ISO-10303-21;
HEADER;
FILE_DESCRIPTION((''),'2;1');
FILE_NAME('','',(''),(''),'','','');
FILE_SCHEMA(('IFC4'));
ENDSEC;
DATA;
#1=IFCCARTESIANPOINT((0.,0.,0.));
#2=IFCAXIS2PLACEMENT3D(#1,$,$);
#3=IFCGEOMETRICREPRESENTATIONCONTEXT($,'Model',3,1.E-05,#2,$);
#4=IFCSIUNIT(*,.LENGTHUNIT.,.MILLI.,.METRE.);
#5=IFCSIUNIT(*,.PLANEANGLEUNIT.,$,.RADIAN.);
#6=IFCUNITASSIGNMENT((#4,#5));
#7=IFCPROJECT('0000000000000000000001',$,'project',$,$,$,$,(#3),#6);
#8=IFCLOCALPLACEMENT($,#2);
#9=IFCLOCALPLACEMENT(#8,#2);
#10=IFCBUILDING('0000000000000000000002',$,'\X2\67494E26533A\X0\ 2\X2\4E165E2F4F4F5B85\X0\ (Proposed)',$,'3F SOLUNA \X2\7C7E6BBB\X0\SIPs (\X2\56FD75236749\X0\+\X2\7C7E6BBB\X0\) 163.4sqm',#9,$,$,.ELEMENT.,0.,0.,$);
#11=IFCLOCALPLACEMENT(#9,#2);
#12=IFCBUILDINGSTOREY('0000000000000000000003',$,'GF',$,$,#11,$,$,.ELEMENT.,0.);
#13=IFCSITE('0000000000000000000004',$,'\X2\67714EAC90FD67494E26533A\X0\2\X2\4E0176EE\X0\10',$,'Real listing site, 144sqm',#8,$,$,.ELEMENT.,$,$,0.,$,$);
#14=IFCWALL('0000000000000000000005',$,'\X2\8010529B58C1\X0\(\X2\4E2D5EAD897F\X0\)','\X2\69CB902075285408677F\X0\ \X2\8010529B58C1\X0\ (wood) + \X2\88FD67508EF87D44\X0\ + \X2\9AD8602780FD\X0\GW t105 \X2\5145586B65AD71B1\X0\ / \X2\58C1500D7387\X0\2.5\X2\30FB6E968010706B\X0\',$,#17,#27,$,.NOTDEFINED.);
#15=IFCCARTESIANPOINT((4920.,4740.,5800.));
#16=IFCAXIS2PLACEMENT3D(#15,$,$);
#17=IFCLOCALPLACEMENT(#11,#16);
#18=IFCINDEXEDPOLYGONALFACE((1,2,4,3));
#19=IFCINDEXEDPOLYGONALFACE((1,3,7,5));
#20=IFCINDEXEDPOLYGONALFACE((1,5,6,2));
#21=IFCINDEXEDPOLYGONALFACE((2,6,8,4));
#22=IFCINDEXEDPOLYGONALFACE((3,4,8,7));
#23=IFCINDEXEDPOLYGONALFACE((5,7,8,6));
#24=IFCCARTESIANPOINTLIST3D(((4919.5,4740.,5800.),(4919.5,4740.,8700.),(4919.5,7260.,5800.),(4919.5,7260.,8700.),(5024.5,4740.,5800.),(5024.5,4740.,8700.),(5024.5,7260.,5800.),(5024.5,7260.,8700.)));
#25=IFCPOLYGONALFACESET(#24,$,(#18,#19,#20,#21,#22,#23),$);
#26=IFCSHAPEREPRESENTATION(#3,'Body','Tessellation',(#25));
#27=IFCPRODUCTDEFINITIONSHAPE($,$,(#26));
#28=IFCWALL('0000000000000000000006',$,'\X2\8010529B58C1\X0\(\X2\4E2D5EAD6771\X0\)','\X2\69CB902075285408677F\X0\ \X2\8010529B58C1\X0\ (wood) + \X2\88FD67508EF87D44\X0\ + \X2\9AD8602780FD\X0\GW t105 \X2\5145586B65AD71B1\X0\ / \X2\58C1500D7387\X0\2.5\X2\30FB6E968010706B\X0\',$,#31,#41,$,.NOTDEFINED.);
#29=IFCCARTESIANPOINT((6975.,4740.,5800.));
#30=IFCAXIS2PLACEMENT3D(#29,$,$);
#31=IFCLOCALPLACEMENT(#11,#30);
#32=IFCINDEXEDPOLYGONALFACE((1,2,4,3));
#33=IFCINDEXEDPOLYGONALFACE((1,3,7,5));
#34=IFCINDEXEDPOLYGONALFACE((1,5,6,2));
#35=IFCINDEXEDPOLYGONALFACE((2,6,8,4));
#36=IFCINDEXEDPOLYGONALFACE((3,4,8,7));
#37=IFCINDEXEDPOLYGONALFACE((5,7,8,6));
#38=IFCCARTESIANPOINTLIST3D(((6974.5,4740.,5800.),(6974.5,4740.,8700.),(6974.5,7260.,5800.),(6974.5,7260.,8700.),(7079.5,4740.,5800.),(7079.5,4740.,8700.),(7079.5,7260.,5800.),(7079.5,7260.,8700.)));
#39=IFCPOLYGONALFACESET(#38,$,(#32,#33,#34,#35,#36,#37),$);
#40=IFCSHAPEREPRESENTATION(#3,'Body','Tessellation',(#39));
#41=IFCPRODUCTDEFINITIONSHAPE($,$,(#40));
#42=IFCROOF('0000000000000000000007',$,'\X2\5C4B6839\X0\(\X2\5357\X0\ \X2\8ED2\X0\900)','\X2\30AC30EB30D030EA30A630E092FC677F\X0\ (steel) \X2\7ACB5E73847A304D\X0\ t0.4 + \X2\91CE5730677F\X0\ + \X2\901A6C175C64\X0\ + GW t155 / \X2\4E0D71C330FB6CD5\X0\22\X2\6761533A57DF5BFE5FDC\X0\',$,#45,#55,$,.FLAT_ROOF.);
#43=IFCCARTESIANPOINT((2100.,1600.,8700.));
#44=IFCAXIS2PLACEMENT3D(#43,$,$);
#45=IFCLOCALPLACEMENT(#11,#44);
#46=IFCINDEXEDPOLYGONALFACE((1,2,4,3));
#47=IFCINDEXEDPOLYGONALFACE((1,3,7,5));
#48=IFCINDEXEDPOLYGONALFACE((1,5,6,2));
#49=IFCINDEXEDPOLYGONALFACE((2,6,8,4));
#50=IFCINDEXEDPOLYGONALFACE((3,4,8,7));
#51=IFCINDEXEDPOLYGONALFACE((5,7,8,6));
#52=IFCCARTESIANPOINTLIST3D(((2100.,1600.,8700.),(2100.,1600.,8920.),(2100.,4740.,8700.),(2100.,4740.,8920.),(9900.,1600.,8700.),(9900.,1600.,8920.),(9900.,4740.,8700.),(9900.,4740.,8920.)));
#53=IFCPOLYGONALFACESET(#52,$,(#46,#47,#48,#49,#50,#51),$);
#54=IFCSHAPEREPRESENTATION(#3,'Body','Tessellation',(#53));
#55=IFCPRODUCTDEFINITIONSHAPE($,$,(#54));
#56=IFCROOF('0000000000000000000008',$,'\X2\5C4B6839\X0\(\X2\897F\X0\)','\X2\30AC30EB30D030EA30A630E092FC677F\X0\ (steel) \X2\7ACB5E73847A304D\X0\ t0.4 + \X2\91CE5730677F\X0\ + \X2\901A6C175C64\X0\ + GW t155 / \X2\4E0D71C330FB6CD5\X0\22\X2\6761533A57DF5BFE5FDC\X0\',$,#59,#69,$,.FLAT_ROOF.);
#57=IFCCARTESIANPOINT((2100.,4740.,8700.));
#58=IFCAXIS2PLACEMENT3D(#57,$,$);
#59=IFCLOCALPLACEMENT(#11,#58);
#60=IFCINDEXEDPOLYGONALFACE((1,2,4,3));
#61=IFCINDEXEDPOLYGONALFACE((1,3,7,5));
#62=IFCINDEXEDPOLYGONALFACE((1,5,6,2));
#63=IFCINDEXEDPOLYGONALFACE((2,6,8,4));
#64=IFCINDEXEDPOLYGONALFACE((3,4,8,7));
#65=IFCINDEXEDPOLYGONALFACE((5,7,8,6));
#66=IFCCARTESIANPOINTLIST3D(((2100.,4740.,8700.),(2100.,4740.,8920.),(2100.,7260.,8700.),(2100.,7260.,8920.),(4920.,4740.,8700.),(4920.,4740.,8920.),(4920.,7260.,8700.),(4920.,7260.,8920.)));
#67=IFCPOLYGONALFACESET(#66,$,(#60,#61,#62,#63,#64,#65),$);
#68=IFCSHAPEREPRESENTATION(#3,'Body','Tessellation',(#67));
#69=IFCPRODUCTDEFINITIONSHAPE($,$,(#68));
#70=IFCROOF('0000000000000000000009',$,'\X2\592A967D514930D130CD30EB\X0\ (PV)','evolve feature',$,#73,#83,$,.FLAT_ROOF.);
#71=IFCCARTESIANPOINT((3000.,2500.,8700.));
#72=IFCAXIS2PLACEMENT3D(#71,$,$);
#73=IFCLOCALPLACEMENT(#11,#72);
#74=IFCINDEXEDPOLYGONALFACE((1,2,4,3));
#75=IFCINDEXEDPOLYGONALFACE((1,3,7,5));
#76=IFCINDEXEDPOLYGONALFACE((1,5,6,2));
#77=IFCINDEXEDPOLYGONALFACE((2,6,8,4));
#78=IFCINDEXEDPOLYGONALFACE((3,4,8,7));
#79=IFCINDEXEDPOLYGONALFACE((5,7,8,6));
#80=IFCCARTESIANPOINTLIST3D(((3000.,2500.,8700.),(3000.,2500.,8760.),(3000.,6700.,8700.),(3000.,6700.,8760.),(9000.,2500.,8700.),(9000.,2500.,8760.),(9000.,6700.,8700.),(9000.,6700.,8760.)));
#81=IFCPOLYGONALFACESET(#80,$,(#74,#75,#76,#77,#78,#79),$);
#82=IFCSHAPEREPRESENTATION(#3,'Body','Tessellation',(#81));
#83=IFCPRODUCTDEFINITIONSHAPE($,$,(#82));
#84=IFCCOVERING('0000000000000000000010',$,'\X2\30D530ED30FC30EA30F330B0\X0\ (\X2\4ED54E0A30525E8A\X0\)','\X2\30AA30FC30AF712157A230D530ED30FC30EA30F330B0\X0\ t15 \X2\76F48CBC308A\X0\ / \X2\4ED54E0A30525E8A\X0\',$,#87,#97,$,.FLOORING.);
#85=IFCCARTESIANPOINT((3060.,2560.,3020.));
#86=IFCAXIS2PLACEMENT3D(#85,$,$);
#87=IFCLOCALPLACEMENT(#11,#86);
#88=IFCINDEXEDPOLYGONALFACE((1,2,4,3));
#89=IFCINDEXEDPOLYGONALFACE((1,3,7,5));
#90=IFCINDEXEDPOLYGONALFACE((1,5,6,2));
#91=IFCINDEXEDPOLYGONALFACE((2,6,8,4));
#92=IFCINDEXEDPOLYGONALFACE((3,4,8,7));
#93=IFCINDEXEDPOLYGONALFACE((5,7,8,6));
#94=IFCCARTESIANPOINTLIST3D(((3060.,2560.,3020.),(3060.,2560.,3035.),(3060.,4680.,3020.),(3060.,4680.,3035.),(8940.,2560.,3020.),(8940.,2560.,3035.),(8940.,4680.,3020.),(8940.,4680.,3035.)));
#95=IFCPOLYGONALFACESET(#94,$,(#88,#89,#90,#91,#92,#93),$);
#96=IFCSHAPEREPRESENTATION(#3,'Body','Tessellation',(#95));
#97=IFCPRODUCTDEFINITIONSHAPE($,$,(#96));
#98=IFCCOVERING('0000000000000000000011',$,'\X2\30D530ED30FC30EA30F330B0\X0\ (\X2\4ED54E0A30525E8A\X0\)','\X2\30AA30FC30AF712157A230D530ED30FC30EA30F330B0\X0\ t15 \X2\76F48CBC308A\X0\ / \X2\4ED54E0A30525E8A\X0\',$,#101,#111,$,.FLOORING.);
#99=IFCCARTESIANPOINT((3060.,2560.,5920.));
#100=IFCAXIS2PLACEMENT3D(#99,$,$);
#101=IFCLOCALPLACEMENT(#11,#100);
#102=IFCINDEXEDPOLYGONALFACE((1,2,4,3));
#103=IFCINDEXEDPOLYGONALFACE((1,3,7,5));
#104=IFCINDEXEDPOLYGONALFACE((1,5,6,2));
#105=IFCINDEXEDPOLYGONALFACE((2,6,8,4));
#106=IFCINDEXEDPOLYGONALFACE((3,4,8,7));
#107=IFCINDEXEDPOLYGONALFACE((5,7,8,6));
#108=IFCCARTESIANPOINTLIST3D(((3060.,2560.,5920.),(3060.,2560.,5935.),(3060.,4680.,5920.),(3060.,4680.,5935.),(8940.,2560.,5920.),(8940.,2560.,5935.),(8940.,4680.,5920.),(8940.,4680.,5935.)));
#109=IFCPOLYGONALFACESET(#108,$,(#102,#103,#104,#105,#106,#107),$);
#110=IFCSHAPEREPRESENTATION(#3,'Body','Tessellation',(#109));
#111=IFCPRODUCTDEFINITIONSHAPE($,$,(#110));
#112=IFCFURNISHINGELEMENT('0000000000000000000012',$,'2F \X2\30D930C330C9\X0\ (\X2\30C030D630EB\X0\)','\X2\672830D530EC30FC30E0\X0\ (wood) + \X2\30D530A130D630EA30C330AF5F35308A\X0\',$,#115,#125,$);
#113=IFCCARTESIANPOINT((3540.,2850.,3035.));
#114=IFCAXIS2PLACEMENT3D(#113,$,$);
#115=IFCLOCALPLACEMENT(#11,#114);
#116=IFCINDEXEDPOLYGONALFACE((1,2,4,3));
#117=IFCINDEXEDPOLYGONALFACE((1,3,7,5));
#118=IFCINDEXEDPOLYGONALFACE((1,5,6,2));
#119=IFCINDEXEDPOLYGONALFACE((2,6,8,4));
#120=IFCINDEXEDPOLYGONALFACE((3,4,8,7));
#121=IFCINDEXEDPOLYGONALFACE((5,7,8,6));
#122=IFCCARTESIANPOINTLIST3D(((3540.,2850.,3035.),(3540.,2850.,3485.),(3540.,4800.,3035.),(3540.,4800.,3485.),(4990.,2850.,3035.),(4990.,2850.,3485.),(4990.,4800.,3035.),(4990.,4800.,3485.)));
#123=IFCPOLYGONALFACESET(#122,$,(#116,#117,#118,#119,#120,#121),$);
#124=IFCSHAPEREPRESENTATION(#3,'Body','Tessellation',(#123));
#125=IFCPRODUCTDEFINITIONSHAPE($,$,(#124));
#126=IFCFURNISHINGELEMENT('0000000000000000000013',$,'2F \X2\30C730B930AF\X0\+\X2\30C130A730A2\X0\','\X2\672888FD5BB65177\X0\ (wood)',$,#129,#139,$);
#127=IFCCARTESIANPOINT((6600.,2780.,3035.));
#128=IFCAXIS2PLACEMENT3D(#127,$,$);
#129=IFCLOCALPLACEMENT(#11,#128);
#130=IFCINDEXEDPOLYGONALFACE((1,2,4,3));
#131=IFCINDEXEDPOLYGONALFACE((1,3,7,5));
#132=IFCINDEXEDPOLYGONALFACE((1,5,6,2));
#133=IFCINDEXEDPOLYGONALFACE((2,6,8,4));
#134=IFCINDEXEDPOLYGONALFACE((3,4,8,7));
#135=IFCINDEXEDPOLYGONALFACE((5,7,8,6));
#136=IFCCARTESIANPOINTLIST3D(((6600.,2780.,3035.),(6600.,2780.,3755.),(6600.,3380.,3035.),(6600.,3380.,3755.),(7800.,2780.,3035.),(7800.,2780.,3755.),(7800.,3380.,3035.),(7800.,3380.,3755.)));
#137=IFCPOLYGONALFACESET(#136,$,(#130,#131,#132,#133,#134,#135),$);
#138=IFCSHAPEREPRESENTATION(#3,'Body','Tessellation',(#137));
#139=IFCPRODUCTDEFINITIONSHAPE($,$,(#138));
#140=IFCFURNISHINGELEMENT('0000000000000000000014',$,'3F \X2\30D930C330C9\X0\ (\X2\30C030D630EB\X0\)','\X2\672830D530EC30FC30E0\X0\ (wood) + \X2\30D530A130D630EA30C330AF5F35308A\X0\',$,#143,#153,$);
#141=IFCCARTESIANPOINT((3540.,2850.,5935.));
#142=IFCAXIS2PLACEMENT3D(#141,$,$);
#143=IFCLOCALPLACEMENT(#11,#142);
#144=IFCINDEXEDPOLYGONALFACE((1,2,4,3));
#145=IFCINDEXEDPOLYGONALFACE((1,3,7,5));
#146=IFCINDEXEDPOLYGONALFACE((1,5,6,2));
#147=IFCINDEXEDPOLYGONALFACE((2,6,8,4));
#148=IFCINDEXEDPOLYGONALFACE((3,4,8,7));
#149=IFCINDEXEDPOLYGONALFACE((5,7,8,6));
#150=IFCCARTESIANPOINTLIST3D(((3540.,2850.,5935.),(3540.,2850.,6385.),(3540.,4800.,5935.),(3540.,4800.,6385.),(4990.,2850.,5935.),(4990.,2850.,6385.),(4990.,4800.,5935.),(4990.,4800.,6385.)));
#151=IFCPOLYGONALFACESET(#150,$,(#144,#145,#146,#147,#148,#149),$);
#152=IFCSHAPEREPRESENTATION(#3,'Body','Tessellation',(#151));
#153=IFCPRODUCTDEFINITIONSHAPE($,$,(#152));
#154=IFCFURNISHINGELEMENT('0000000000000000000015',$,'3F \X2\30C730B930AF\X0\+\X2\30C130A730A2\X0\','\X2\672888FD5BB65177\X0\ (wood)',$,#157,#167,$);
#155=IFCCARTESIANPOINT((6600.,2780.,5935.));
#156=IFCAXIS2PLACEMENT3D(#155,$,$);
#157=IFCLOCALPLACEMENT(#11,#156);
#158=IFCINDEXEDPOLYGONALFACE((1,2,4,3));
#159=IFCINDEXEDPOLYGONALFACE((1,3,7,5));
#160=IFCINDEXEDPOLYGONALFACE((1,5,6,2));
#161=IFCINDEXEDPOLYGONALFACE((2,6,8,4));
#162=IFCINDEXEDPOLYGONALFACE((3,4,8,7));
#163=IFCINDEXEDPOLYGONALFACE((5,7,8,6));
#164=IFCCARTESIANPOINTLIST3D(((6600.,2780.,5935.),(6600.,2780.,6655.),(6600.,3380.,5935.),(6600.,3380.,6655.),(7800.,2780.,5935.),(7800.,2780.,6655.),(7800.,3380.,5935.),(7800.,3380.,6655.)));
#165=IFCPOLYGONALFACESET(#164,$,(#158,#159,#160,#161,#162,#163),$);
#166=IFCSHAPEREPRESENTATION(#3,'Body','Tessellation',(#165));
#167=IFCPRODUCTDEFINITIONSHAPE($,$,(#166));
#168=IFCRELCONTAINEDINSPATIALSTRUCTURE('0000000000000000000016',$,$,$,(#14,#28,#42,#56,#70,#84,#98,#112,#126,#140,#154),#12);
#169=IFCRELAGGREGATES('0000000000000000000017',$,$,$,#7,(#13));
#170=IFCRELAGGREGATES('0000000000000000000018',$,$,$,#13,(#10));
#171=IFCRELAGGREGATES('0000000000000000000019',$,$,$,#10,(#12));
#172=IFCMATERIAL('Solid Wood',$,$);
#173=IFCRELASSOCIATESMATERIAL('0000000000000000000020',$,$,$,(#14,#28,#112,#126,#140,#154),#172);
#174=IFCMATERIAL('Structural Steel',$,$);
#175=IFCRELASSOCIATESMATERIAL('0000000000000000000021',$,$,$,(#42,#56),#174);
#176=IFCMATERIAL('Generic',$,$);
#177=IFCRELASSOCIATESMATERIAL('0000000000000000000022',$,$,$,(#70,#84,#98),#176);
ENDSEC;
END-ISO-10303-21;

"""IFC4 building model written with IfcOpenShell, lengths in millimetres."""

from ifc_helpers import new_model, si_unit, frame, frame_2d, origin, place, context, project, spatial, rectangle, extrude, material, element, save


model = new_model("IFC4")

# Units and contexts
model_context = context("Model", 3, precision=1e-05, world=origin())
ifc_project = project(units=[si_unit("LENGTHUNIT", "METRE", prefix="MILLI"), si_unit("PLANEANGLEUNIT", "RADIAN")], contexts=[model_context])

# Site, building, storey
site_placement = place(None, origin())
site = spatial("IfcSite", under=ifc_project, at=site_placement, Name="東京都杉並区2丁目10", ObjectType="Real listing site, 144sqm", CompositionType="ELEMENT", RefElevation=0.0)
building_placement = place(site_placement, origin())
building = spatial("IfcBuilding", under=site, at=building_placement, Name="杉並区 2世帯住宅 (Proposed)", ObjectType="3F SOLUNA 籾殻SIPs (国産杉+籾殻) 163.4sqm", CompositionType="ELEMENT", ElevationOfRefHeight=0.0, ElevationOfTerrain=0.0)
storey_placement = place(building_placement, origin())
storey = spatial("IfcBuildingStorey", under=building, at=storey_placement, Name="GF", CompositionType="ELEMENT", Elevation=0.0)

# Shared definitions
ifc_material_1 = material(Name="Solid Wood")

# Walls
wall_1_placement = place(storey_placement, frame((4920.0, 4740.0, 5800.0)))
element("IfcWall", 1, at=wall_1_placement, inside=storey, material=ifc_material_1, Name="耐力壁(中庭西)", Description="構造用合板 耐力壁 (wood) + 製材軸組 + 高性能GW t105 充填断熱 / 壁倍率2.5・準耐火", PredefinedType="NOTDEFINED", context=model_context, shape_type="SweptSolid", body=[
    extrude(rectangle(XDim=105.0, YDim=2520.0, at=frame_2d((52.0, 1260.0))), frame((4920.0, 4740.0, 5800.0)), (0.0, 0.0, 1.0), 2900.0),
])
wall_2_placement = place(storey_placement, frame((6975.0, 4740.0, 5800.0)))
element("IfcWall", 2, at=wall_2_placement, inside=storey, material=ifc_material_1, Name="耐力壁(中庭東)", Description="構造用合板 耐力壁 (wood) + 製材軸組 + 高性能GW t105 充填断熱 / 壁倍率2.5・準耐火", PredefinedType="NOTDEFINED", context=model_context, shape_type="SweptSolid", body=[
    extrude(rectangle(XDim=105.0, YDim=2520.0, at=frame_2d((52.0, 1260.0))), frame((6975.0, 4740.0, 5800.0)), (0.0, 0.0, 1.0), 2900.0),
])

# Roofs
ifc_material_2 = material(Name="Structural Steel")
roof_1_placement = place(storey_placement, frame((2100.0, 1600.0, 8700.0)))
element("IfcRoof", 3, at=roof_1_placement, inside=storey, material=ifc_material_2, Name="屋根(南 軒900)", Description="ガルバリウム鋼板 (steel) 立平葺き t0.4 + 野地板 + 通気層 + GW t155 / 不燃・法22条区域対応", PredefinedType="FLAT_ROOF", context=model_context, shape_type="SweptSolid", body=[
    extrude(rectangle(XDim=7800.0, YDim=3140.0, at=frame_2d((3900.0, 1570.0))), frame((2100.0, 1600.0, 8700.0)), (0.0, 0.0, 1.0), 220.0),
])
roof_2_placement = place(storey_placement, frame((2100.0, 4740.0, 8700.0)))
element("IfcRoof", 4, at=roof_2_placement, inside=storey, material=ifc_material_2, Name="屋根(西)", Description="ガルバリウム鋼板 (steel) 立平葺き t0.4 + 野地板 + 通気層 + GW t155 / 不燃・法22条区域対応", PredefinedType="FLAT_ROOF", context=model_context, shape_type="SweptSolid", body=[
    extrude(rectangle(XDim=2820.0, YDim=2520.0, at=frame_2d((1410.0, 1260.0))), frame((2100.0, 4740.0, 8700.0)), (0.0, 0.0, 1.0), 220.0),
])
ifc_material_3 = material(Name="Generic")
roof_3_placement = place(storey_placement, frame((3000.0, 2500.0, 8700.0)))
element("IfcRoof", 5, at=roof_3_placement, inside=storey, material=ifc_material_3, Name="太陽光パネル (PV)", Description="evolve feature", PredefinedType="FLAT_ROOF", context=model_context, shape_type="SweptSolid", body=[
    extrude(rectangle(XDim=6000.0, YDim=4200.0, at=frame_2d((3000.0, 2100.0))), frame((3000.0, 2500.0, 8700.0)), (0.0, 0.0, 1.0), 60.0),
])

# Coverings
covering_1_placement = place(storey_placement, frame((3060.0, 2560.0, 3020.0)))
element("IfcCovering", 6, at=covering_1_placement, inside=storey, material=ifc_material_3, Name="フローリング (仕上げ床)", Description="オーク無垢フローリング t15 直貼り / 仕上げ床", PredefinedType="FLOORING", context=model_context, shape_type="SweptSolid", body=[
    extrude(rectangle(XDim=5880.0, YDim=2120.0, at=frame_2d((2940.0, 1060.0))), frame((3060.0, 2560.0, 3020.0)), (0.0, 0.0, 1.0), 15.0),
])
covering_2_placement = place(storey_placement, frame((3060.0, 2560.0, 5920.0)))
element("IfcCovering", 7, at=covering_2_placement, inside=storey, material=ifc_material_3, Name="フローリング (仕上げ床)", Description="オーク無垢フローリング t15 直貼り / 仕上げ床", PredefinedType="FLOORING", context=model_context, shape_type="SweptSolid", body=[
    extrude(rectangle(XDim=5880.0, YDim=2120.0, at=frame_2d((2940.0, 1060.0))), frame((3060.0, 2560.0, 5920.0)), (0.0, 0.0, 1.0), 15.0),
])

# Furnishing elements
furnishing_1_placement = place(storey_placement, frame((3540.0, 2850.0, 3035.0)))
element("IfcFurnishingElement", 8, at=furnishing_1_placement, inside=storey, material=ifc_material_1, Name="2F ベッド (ダブル)", Description="木フレーム (wood) + ファブリック張り", context=model_context, shape_type="SweptSolid", body=[
    extrude(rectangle(XDim=1450.0, YDim=1950.0, at=frame_2d((725.0, 975.0))), frame((3540.0, 2850.0, 3035.0)), (0.0, 0.0, 1.0), 450.0),
])
furnishing_2_placement = place(storey_placement, frame((6600.0, 2780.0, 3035.0)))
element("IfcFurnishingElement", 9, at=furnishing_2_placement, inside=storey, material=ifc_material_1, Name="2F デスク+チェア", Description="木製家具 (wood)", context=model_context, shape_type="SweptSolid", body=[
    extrude(rectangle(XDim=1200.0, YDim=600.0, at=frame_2d((600.0, 300.0))), frame((6600.0, 2780.0, 3035.0)), (0.0, 0.0, 1.0), 720.0),
])
furnishing_3_placement = place(storey_placement, frame((3540.0, 2850.0, 5935.0)))
element("IfcFurnishingElement", 10, at=furnishing_3_placement, inside=storey, material=ifc_material_1, Name="3F ベッド (ダブル)", Description="木フレーム (wood) + ファブリック張り", context=model_context, shape_type="SweptSolid", body=[
    extrude(rectangle(XDim=1450.0, YDim=1950.0, at=frame_2d((725.0, 975.0))), frame((3540.0, 2850.0, 5935.0)), (0.0, 0.0, 1.0), 450.0),
])
furnishing_4_placement = place(storey_placement, frame((6600.0, 2780.0, 5935.0)))
element("IfcFurnishingElement", 11, at=furnishing_4_placement, inside=storey, material=ifc_material_1, Name="3F デスク+チェア", Description="木製家具 (wood)", context=model_context, shape_type="SweptSolid", body=[
    extrude(rectangle(XDim=1200.0, YDim=600.0, at=frame_2d((600.0, 300.0))), frame((6600.0, 2780.0, 5935.0)), (0.0, 0.0, 1.0), 720.0),
])

save(model, "model.ifc")
